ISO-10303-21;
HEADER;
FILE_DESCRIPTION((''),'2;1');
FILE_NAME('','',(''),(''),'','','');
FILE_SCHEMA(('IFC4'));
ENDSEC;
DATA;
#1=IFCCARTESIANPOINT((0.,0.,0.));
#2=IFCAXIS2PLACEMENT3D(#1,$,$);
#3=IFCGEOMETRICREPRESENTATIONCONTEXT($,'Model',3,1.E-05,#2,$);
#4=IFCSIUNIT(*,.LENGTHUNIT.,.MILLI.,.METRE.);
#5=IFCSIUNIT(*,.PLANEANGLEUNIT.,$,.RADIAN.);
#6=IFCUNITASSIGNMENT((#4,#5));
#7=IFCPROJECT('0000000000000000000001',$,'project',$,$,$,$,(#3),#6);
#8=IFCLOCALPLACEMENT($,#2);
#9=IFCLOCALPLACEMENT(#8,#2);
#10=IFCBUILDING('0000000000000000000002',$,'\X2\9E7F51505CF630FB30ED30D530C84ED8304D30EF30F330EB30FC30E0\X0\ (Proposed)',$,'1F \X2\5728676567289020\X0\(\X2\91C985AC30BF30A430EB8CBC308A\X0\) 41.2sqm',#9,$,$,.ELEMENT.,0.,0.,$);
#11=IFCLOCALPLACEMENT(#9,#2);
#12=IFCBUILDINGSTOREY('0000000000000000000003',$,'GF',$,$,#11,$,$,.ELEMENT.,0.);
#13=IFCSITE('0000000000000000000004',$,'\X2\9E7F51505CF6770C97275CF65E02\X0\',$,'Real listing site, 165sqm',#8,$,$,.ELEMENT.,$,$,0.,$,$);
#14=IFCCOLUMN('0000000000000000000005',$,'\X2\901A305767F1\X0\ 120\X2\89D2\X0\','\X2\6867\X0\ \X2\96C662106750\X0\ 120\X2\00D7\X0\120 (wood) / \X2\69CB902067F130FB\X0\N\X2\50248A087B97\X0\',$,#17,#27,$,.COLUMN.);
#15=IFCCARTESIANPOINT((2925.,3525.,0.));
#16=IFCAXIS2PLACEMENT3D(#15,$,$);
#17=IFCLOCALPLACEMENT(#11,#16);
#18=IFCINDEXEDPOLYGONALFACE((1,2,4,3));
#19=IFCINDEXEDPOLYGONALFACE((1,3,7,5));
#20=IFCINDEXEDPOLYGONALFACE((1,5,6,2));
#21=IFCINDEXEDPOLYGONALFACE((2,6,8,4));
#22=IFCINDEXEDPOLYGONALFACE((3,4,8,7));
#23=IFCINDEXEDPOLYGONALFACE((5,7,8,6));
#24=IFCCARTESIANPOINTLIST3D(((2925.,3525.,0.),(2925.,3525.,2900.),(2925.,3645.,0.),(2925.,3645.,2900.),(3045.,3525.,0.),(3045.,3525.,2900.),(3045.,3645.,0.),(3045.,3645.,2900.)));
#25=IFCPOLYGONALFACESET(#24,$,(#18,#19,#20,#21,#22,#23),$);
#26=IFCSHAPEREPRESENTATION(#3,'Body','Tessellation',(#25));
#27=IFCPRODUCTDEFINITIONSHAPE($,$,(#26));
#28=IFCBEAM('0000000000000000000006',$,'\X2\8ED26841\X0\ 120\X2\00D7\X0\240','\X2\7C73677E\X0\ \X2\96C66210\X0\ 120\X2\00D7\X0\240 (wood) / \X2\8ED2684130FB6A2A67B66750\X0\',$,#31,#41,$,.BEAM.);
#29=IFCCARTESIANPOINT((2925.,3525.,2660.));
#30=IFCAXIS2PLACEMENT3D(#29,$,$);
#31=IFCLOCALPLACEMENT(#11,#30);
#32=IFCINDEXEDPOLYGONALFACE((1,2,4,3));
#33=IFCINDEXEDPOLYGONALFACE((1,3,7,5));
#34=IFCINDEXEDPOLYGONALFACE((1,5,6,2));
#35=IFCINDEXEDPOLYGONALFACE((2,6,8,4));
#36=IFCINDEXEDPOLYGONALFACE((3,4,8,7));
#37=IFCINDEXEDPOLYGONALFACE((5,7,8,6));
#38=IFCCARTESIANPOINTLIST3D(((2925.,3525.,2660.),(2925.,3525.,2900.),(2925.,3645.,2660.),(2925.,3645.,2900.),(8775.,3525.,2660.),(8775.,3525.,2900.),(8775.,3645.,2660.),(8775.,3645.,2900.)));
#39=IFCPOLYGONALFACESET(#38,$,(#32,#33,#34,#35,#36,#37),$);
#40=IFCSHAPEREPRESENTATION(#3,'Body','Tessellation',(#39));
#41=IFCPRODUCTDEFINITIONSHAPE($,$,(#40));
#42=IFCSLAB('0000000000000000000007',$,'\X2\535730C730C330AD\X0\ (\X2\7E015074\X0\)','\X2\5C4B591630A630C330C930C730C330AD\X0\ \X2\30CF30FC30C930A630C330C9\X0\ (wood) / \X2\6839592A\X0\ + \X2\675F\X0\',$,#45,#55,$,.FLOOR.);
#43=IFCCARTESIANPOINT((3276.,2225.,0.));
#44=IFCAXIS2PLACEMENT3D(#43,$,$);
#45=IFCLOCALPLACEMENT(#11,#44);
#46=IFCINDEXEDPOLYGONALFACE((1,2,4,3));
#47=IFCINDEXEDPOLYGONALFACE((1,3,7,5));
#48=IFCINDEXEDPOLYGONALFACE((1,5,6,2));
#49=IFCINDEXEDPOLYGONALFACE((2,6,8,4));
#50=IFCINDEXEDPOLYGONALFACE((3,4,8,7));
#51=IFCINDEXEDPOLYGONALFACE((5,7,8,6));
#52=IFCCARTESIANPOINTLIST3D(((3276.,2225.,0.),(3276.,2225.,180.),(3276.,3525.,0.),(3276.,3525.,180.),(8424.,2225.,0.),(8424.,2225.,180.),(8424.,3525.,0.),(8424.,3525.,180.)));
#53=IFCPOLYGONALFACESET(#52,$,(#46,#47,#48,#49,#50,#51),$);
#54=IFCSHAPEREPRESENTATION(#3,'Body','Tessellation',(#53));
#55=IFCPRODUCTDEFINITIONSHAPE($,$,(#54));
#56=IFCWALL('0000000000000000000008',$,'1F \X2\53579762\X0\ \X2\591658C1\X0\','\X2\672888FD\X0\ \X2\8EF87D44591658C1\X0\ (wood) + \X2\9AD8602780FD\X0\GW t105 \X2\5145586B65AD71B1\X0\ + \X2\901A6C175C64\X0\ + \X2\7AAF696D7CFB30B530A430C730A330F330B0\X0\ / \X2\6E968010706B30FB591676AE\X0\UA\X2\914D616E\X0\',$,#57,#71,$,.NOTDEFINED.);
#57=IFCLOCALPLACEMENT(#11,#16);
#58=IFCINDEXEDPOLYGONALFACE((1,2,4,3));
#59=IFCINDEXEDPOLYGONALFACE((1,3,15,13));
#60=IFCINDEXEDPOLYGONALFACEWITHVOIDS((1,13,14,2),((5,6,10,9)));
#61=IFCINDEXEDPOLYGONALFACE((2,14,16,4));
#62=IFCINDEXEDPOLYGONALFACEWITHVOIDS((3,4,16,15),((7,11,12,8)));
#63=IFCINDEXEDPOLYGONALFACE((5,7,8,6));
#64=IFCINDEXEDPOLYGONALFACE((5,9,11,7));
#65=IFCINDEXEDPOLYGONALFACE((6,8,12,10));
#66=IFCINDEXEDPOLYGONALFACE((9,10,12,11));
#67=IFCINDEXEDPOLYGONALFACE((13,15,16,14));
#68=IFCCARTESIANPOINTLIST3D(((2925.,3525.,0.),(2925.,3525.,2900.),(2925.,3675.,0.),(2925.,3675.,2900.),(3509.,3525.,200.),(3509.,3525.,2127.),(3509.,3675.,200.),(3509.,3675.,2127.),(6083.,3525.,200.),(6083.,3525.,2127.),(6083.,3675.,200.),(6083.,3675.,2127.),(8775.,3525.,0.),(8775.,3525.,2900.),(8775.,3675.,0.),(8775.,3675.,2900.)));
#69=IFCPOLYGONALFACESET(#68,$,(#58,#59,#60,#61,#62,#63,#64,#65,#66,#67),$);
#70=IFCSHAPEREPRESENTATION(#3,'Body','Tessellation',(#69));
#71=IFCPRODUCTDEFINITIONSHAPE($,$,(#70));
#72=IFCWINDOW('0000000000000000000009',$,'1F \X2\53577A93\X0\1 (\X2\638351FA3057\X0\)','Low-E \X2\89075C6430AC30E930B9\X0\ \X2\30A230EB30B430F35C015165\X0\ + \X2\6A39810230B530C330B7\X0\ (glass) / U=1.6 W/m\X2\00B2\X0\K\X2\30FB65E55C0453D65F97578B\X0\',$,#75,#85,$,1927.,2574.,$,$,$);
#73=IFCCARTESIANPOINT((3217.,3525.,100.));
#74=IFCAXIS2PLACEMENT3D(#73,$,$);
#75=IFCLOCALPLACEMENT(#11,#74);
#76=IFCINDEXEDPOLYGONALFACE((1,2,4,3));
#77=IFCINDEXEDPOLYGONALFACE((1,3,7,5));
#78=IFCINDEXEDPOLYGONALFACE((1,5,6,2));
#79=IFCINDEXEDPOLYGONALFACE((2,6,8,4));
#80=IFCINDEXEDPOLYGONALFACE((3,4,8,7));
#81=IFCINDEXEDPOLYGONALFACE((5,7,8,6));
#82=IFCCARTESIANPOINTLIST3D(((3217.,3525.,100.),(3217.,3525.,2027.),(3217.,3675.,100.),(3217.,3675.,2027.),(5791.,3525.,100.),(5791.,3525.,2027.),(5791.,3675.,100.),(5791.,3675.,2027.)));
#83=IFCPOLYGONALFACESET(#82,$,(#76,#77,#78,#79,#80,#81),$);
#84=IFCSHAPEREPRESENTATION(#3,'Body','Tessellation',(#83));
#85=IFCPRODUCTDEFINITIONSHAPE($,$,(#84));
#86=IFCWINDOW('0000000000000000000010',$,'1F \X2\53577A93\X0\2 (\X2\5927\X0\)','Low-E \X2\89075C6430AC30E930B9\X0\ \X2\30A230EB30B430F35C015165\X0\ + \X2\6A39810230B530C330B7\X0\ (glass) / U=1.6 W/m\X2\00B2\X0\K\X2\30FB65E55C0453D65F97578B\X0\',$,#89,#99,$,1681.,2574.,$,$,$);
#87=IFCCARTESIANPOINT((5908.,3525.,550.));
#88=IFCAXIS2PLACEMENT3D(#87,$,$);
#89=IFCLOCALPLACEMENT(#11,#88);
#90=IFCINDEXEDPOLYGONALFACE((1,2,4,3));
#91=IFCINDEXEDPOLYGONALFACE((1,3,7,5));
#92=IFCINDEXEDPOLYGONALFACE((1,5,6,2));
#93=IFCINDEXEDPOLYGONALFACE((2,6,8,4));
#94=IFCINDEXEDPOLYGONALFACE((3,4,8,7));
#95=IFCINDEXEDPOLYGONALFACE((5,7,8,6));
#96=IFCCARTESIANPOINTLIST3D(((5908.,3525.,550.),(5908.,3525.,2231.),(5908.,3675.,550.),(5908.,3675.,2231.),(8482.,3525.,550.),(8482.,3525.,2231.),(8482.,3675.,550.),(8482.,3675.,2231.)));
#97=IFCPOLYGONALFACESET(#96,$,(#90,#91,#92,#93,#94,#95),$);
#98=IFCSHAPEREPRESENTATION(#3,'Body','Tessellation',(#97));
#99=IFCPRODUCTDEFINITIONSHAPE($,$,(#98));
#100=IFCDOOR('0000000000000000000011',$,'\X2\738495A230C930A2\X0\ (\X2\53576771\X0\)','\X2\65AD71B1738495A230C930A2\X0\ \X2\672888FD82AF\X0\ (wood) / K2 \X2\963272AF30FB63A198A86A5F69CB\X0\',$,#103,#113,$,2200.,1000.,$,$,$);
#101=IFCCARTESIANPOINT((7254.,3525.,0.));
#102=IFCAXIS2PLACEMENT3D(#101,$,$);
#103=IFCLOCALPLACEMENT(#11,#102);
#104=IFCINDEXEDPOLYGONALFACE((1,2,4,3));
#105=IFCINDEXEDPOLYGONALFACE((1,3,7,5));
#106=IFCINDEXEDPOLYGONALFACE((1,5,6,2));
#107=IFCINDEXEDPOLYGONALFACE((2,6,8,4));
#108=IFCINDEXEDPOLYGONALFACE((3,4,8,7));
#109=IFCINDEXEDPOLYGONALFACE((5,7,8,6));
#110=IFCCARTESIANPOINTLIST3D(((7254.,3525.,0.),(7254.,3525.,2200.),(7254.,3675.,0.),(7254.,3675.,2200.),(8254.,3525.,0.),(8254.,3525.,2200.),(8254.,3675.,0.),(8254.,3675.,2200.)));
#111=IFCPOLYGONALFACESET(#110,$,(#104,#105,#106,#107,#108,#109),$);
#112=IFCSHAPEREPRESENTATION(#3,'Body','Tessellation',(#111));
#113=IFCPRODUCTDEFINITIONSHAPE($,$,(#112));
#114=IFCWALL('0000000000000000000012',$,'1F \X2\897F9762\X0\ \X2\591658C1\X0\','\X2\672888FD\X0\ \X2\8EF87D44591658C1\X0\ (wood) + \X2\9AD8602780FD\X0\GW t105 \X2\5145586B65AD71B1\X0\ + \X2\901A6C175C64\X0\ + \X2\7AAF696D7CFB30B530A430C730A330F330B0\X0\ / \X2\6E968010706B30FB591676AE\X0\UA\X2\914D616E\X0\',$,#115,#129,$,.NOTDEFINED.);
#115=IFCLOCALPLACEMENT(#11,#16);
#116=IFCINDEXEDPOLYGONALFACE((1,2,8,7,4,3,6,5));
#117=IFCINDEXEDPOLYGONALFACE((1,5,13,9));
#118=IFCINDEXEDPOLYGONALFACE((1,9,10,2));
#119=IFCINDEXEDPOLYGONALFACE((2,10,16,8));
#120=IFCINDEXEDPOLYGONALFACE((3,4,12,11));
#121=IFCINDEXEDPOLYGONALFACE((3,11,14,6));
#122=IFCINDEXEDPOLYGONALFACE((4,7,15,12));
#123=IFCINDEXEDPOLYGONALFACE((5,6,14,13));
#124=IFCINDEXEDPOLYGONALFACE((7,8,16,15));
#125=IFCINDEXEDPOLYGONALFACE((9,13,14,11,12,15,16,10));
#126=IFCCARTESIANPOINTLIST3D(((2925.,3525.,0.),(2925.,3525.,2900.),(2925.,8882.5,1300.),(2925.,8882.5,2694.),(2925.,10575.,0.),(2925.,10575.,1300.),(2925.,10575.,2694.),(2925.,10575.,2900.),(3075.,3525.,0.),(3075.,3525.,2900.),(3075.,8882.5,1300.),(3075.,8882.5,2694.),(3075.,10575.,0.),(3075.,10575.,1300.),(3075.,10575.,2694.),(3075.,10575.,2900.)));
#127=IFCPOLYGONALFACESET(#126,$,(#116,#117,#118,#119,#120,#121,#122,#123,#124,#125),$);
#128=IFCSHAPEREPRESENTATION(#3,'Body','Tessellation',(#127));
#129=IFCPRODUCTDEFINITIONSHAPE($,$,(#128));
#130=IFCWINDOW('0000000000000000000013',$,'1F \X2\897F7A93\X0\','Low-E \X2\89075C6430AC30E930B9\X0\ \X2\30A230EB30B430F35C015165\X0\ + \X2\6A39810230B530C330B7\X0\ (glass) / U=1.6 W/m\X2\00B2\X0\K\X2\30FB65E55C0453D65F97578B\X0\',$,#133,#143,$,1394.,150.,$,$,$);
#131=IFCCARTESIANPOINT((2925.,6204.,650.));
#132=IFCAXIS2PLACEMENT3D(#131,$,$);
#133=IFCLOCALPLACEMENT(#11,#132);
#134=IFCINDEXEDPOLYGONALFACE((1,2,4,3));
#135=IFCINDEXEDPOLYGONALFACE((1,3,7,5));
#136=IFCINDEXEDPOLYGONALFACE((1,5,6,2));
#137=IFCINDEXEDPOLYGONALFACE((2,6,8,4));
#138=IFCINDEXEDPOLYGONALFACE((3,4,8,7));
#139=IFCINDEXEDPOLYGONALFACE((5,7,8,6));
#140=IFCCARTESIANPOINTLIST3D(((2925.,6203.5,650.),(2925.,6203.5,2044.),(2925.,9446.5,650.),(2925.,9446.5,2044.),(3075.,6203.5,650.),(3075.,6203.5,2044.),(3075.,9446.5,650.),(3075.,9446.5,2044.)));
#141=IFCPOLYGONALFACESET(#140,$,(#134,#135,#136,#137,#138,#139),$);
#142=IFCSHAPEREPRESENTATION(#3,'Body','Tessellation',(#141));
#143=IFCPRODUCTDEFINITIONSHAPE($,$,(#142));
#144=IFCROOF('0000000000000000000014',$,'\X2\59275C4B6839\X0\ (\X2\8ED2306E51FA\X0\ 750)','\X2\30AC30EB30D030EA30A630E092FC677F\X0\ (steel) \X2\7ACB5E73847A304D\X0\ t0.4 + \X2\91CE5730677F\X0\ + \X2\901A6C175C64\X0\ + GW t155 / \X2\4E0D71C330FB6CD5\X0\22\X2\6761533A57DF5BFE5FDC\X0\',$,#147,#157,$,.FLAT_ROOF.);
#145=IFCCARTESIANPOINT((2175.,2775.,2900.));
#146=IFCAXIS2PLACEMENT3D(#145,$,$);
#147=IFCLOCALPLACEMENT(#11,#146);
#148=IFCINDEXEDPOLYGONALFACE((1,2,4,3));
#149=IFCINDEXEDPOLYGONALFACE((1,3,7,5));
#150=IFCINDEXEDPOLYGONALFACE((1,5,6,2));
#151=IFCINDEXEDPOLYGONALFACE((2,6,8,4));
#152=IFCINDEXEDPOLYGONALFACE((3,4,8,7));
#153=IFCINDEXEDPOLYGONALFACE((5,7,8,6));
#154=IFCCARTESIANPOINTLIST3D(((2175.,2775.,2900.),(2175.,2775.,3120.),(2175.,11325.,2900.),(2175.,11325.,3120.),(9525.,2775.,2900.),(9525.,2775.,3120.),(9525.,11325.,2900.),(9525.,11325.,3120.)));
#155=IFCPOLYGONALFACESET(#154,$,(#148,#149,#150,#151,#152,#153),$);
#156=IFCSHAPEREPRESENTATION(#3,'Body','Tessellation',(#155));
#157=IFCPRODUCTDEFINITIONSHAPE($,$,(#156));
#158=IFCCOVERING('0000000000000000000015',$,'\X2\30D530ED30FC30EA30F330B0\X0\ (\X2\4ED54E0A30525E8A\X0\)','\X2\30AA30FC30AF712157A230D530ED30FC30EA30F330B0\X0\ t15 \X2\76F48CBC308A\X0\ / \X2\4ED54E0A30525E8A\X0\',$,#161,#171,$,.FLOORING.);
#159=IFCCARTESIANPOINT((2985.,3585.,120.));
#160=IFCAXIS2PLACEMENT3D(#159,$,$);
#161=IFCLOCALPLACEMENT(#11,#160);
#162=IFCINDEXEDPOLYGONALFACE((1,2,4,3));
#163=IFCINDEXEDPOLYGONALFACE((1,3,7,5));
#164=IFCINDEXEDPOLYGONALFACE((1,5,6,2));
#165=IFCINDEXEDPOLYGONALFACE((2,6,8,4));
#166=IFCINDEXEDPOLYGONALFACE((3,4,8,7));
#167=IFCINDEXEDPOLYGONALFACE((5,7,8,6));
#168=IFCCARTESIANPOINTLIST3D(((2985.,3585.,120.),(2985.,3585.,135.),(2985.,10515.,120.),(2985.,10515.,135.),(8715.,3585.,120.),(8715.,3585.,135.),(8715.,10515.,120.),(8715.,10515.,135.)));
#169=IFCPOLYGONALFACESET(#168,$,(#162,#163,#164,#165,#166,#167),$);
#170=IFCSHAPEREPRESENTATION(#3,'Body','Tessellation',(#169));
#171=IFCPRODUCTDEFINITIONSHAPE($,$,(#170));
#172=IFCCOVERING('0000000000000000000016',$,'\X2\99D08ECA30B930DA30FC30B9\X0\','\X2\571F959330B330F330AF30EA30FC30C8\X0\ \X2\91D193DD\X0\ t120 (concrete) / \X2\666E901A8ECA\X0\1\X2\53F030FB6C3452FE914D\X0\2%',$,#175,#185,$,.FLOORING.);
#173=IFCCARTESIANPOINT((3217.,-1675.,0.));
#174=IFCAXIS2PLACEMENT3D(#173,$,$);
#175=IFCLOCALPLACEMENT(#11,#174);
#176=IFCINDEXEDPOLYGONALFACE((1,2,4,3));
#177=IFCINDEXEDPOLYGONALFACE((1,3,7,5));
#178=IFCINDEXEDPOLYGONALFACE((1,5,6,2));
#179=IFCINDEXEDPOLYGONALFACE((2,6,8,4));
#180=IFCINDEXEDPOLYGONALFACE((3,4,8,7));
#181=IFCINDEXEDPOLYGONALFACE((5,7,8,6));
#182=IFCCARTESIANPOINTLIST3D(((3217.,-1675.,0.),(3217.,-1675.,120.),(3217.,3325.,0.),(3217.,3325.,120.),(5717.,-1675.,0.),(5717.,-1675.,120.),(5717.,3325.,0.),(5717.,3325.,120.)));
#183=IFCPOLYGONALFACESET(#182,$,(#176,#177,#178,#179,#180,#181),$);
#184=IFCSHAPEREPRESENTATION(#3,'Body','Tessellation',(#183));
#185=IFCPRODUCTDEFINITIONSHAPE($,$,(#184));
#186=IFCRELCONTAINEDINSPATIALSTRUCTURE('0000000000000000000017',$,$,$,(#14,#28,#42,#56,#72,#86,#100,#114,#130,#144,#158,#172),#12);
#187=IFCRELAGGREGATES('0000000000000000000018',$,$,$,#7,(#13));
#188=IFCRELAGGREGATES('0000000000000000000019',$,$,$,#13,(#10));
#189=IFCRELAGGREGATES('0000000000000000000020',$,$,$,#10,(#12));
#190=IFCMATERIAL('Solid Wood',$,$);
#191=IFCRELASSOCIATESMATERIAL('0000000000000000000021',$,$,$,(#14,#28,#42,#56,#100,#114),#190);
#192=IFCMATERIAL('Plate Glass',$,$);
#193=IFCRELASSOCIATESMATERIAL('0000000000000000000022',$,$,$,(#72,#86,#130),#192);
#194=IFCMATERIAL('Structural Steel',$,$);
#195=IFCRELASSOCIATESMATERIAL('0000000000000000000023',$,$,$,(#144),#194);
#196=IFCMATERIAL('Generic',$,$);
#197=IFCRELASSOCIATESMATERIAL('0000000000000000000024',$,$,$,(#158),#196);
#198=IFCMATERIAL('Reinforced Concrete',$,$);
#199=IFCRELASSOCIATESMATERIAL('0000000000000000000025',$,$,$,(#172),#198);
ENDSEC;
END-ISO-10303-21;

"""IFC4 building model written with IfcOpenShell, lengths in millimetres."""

from ifc_helpers import new_model, si_unit, frame, frame_2d, origin, place, context, project, spatial, rectangle, extrude, material, element, fill, save


model = new_model("IFC4")

# Units and contexts
model_context = context("Model", 3, precision=1e-05, world=origin())
ifc_project = project(units=[si_unit("LENGTHUNIT", "METRE", prefix="MILLI"), si_unit("PLANEANGLEUNIT", "RADIAN")], contexts=[model_context])

# Site, building, storey
site_placement = place(None, origin())
site = spatial("IfcSite", under=ifc_project, at=site_placement, Name="鹿児島県霧島市", ObjectType="Real listing site, 165sqm", CompositionType="ELEMENT", RefElevation=0.0)
building_placement = place(site_placement, origin())
building = spatial("IfcBuilding", under=site, at=building_placement, Name="鹿児島・ロフト付きワンルーム (Proposed)", ObjectType="1F 在来木造(釉薬タイル貼り) 41.2sqm", CompositionType="ELEMENT", ElevationOfRefHeight=0.0, ElevationOfTerrain=0.0)
storey_placement = place(building_placement, origin())
storey = spatial("IfcBuildingStorey", under=building, at=storey_placement, Name="GF", CompositionType="ELEMENT", Elevation=0.0)

# Column
ifc_material_1 = material(Name="Solid Wood")
column_placement = place(storey_placement, frame((2925.0, 3525.0, 0.0)))
element("IfcColumn", 1, at=column_placement, inside=storey, material=ifc_material_1, Name="通し柱 120角", Description="桧 集成材 120×120 (wood) / 構造柱・N値計算", PredefinedType="COLUMN", context=model_context, shape_type="SweptSolid", body=[
    extrude(rectangle(XDim=120.0, YDim=120.0, at=frame_2d((60.0, 60.0))), frame((2925.0, 3525.0, 0.0)), (0.0, 0.0, 1.0), 2900.0),
])

# Beam
beam_1_placement = place(storey_placement, frame((2925.0, 3525.0, 2660.0)))
element("IfcBeam", 2, at=beam_1_placement, inside=storey, material=ifc_material_1, Name="軒桁 120×240", Description="米松 集成 120×240 (wood) / 軒桁・横架材", PredefinedType="BEAM", context=model_context, shape_type="SweptSolid", body=[
    extrude(rectangle(XDim=5850.0, YDim=120.0, at=frame_2d((2925.0, 60.0))), frame((2925.0, 3525.0, 2660.0)), (0.0, 0.0, 1.0), 240.0),
])

# Slab
ifc_material_2 = material(Name="Reinforced Concrete")
slab_1_placement = place(storey_placement, frame((3276.0, 2225.0, 0.0)))
element("IfcSlab", 3, at=slab_1_placement, inside=storey, material=ifc_material_1, Name="南デッキ (縁側)", Description="屋外ウッドデッキ ハードウッド (wood) / 根太 + 束", PredefinedType="FLOOR", context=model_context, shape_type="SweptSolid", body=[
    extrude(rectangle(XDim=5148.0, YDim=1300.0, at=frame_2d((2574.0, 650.0))), frame((3276.0, 2225.0, 0.0)), (0.0, 0.0, 1.0), 180.0),
])

# Wall, openings, windows, door
wall_1_placement = place(storey_placement, frame((2925.0, 3525.0, 0.0)))
wall_1 = element("IfcWall", 4, at=wall_1_placement, inside=storey, material=ifc_material_1, Name="1F 南面 外壁", Description="木製 軸組外壁 (wood) + 高性能GW t105 充填断熱 + 通気層 + 窯業系サイディング / 準耐火・外皮UA配慮", PredefinedType="NOTDEFINED", context=model_context, shape_type="SweptSolid", body=[
    extrude(rectangle(XDim=5850.0, YDim=150.0, at=frame_2d((2925.0, 75.0))), frame((2925.0, 3525.0, 0.0)), (0.0, 0.0, 1.0), 2900.0),
])
opening_1_placement = place(storey_placement, frame((3217.0, 3525.0, 100.0)))
opening_1 = element("IfcOpeningElement", 5, at=opening_1_placement, cuts=wall_1, PredefinedType="NOTDEFINED", context=model_context, shape_type="SweptSolid", body=[
    extrude(rectangle(XDim=2574.0, YDim=150.0, at=frame_2d((1287.0, 75.0))), frame((3217.0, 3525.0, 100.0)), (0.0, 0.0, 1.0), 1927.0),
])
opening_2_placement = place(storey_placement, frame((5908.0, 3525.0, 550.0)))
opening_2 = element("IfcOpeningElement", 6, at=opening_2_placement, cuts=wall_1, PredefinedType="NOTDEFINED", context=model_context, shape_type="SweptSolid", body=[
    extrude(rectangle(XDim=2574.0, YDim=150.0, at=frame_2d((1287.0, 75.0))), frame((5908.0, 3525.0, 550.0)), (0.0, 0.0, 1.0), 1681.0),
])
opening_3_placement = place(storey_placement, frame((7254.0, 3525.0, 0.0)))
opening_3 = element("IfcOpeningElement", 7, at=opening_3_placement, cuts=wall_1, PredefinedType="NOTDEFINED", context=model_context, shape_type="SweptSolid", body=[
    extrude(rectangle(XDim=1000.0, YDim=150.0, at=frame_2d((500.0, 75.0))), frame((7254.0, 3525.0, 0.0)), (0.0, 0.0, 1.0), 2200.0),
])
ifc_material_3 = material(Name="Plate Glass")
window_1_placement = place(storey_placement, frame((3217.0, 3525.0, 100.0)))
window_1 = element("IfcWindow", 8, at=window_1_placement, inside=storey, material=ifc_material_3, Name="1F 南窓1 (掃出し)", Description="Low-E 複層ガラス アルゴン封入 + 樹脂サッシ (glass) / U=1.6 W/m²K・日射取得型", OverallHeight=1927.0, OverallWidth=2574.0, context=model_context, shape_type="SweptSolid", body=[
    extrude(rectangle(XDim=2574.0, YDim=150.0, at=frame_2d((1287.0, 75.0))), frame((3217.0, 3525.0, 100.0)), (0.0, 0.0, 1.0), 1927.0),
])
fill(opening_1, window_1)
window_2_placement = place(storey_placement, frame((5908.0, 3525.0, 550.0)))
window_2 = element("IfcWindow", 9, at=window_2_placement, inside=storey, material=ifc_material_3, Name="1F 南窓2 (大)", Description="Low-E 複層ガラス アルゴン封入 + 樹脂サッシ (glass) / U=1.6 W/m²K・日射取得型", OverallHeight=1681.0, OverallWidth=2574.0, context=model_context, shape_type="SweptSolid", body=[
    extrude(rectangle(XDim=2574.0, YDim=150.0, at=frame_2d((1287.0, 75.0))), frame((5908.0, 3525.0, 550.0)), (0.0, 0.0, 1.0), 1681.0),
])
fill(opening_2, window_2)
door_placement = place(storey_placement, frame((7254.0, 3525.0, 0.0)))
door = element("IfcDoor", 10, at=door_placement, inside=storey, material=ifc_material_1, Name="玄関ドア (南東)", Description="断熱玄関ドア 木製芯 (wood) / K2 防犯・採風機構", OverallHeight=2200.0, OverallWidth=1000.0, context=model_context, shape_type="SweptSolid", body=[
    extrude(rectangle(XDim=1000.0, YDim=150.0, at=frame_2d((500.0, 75.0))), frame((7254.0, 3525.0, 0.0)), (0.0, 0.0, 1.0), 2200.0),
])
fill(opening_3, door)

# Wall, opening, window
wall_2_placement = place(storey_placement, frame((2925.0, 3525.0, 0.0)))
wall_2 = element("IfcWall", 11, at=wall_2_placement, inside=storey, material=ifc_material_1, Name="1F 西面 外壁", Description="木製 軸組外壁 (wood) + 高性能GW t105 充填断熱 + 通気層 + 窯業系サイディング / 準耐火・外皮UA配慮", PredefinedType="NOTDEFINED", context=model_context, shape_type="SweptSolid", body=[
    extrude(rectangle(XDim=150.0, YDim=7050.0, at=frame_2d((75.0, 3525.0))), frame((2925.0, 3525.0, 0.0)), (0.0, 0.0, 1.0), 2900.0),
])
opening_4_placement = place(storey_placement, frame((2925.0, 6204.0, 650.0)))
opening_4 = element("IfcOpeningElement", 12, at=opening_4_placement, cuts=wall_2, PredefinedType="NOTDEFINED", context=model_context, shape_type="SweptSolid", body=[
    extrude(rectangle(XDim=150.0, YDim=3243.0, at=frame_2d((75.0, 1621.0))), frame((2925.0, 6204.0, 650.0)), (0.0, 0.0, 1.0), 1394.0),
])
window_3_placement = place(storey_placement, frame((2925.0, 6204.0, 650.0)))
window_3 = element("IfcWindow", 13, at=window_3_placement, inside=storey, material=ifc_material_3, Name="1F 西窓", Description="Low-E 複層ガラス アルゴン封入 + 樹脂サッシ (glass) / U=1.6 W/m²K・日射取得型", OverallHeight=1394.0, OverallWidth=150.0, context=model_context, shape_type="SweptSolid", body=[
    extrude(rectangle(XDim=150.0, YDim=3243.0, at=frame_2d((75.0, 1621.0))), frame((2925.0, 6204.0, 650.0)), (0.0, 0.0, 1.0), 1394.0),
])
fill(opening_4, window_3)

# Roof
ifc_material_4 = material(Name="Structural Steel")
roof_placement = place(storey_placement, frame((2175.0, 2775.0, 2900.0)))
element("IfcRoof", 14, at=roof_placement, inside=storey, material=ifc_material_4, Name="大屋根 (軒の出 750)", Description="ガルバリウム鋼板 (steel) 立平葺き t0.4 + 野地板 + 通気層 + GW t155 / 不燃・法22条区域対応", PredefinedType="FLAT_ROOF", context=model_context, shape_type="SweptSolid", body=[
    extrude(rectangle(XDim=7350.0, YDim=8550.0, at=frame_2d((3675.0, 4275.0))), frame((2175.0, 2775.0, 2900.0)), (0.0, 0.0, 1.0), 220.0),
])

# Coverings
ifc_material_5 = material(Name="Generic")
covering_1_placement = place(storey_placement, frame((2985.0, 3585.0, 120.0)))
element("IfcCovering", 15, at=covering_1_placement, inside=storey, material=ifc_material_5, Name="フローリング (仕上げ床)", Description="オーク無垢フローリング t15 直貼り / 仕上げ床", PredefinedType="FLOORING", context=model_context, shape_type="SweptSolid", body=[
    extrude(rectangle(XDim=5730.0, YDim=6930.0, at=frame_2d((2865.0, 3465.0))), frame((2985.0, 3585.0, 120.0)), (0.0, 0.0, 1.0), 15.0),
])
covering_2_placement = place(storey_placement, frame((3217.0, -1675.0, 0.0)))
element("IfcCovering", 16, at=covering_2_placement, inside=storey, material=ifc_material_2, Name="駐車スペース", Description="土間コンクリート 金鏝 t120 (concrete) / 普通車1台・水勾配2%", PredefinedType="FLOORING", context=model_context, shape_type="SweptSolid", body=[
    extrude(rectangle(XDim=2500.0, YDim=5000.0, at=frame_2d((1250.0, 2500.0))), frame((3217.0, -1675.0, 0.0)), (0.0, 0.0, 1.0), 120.0),
])

save(model, "model.ifc")
